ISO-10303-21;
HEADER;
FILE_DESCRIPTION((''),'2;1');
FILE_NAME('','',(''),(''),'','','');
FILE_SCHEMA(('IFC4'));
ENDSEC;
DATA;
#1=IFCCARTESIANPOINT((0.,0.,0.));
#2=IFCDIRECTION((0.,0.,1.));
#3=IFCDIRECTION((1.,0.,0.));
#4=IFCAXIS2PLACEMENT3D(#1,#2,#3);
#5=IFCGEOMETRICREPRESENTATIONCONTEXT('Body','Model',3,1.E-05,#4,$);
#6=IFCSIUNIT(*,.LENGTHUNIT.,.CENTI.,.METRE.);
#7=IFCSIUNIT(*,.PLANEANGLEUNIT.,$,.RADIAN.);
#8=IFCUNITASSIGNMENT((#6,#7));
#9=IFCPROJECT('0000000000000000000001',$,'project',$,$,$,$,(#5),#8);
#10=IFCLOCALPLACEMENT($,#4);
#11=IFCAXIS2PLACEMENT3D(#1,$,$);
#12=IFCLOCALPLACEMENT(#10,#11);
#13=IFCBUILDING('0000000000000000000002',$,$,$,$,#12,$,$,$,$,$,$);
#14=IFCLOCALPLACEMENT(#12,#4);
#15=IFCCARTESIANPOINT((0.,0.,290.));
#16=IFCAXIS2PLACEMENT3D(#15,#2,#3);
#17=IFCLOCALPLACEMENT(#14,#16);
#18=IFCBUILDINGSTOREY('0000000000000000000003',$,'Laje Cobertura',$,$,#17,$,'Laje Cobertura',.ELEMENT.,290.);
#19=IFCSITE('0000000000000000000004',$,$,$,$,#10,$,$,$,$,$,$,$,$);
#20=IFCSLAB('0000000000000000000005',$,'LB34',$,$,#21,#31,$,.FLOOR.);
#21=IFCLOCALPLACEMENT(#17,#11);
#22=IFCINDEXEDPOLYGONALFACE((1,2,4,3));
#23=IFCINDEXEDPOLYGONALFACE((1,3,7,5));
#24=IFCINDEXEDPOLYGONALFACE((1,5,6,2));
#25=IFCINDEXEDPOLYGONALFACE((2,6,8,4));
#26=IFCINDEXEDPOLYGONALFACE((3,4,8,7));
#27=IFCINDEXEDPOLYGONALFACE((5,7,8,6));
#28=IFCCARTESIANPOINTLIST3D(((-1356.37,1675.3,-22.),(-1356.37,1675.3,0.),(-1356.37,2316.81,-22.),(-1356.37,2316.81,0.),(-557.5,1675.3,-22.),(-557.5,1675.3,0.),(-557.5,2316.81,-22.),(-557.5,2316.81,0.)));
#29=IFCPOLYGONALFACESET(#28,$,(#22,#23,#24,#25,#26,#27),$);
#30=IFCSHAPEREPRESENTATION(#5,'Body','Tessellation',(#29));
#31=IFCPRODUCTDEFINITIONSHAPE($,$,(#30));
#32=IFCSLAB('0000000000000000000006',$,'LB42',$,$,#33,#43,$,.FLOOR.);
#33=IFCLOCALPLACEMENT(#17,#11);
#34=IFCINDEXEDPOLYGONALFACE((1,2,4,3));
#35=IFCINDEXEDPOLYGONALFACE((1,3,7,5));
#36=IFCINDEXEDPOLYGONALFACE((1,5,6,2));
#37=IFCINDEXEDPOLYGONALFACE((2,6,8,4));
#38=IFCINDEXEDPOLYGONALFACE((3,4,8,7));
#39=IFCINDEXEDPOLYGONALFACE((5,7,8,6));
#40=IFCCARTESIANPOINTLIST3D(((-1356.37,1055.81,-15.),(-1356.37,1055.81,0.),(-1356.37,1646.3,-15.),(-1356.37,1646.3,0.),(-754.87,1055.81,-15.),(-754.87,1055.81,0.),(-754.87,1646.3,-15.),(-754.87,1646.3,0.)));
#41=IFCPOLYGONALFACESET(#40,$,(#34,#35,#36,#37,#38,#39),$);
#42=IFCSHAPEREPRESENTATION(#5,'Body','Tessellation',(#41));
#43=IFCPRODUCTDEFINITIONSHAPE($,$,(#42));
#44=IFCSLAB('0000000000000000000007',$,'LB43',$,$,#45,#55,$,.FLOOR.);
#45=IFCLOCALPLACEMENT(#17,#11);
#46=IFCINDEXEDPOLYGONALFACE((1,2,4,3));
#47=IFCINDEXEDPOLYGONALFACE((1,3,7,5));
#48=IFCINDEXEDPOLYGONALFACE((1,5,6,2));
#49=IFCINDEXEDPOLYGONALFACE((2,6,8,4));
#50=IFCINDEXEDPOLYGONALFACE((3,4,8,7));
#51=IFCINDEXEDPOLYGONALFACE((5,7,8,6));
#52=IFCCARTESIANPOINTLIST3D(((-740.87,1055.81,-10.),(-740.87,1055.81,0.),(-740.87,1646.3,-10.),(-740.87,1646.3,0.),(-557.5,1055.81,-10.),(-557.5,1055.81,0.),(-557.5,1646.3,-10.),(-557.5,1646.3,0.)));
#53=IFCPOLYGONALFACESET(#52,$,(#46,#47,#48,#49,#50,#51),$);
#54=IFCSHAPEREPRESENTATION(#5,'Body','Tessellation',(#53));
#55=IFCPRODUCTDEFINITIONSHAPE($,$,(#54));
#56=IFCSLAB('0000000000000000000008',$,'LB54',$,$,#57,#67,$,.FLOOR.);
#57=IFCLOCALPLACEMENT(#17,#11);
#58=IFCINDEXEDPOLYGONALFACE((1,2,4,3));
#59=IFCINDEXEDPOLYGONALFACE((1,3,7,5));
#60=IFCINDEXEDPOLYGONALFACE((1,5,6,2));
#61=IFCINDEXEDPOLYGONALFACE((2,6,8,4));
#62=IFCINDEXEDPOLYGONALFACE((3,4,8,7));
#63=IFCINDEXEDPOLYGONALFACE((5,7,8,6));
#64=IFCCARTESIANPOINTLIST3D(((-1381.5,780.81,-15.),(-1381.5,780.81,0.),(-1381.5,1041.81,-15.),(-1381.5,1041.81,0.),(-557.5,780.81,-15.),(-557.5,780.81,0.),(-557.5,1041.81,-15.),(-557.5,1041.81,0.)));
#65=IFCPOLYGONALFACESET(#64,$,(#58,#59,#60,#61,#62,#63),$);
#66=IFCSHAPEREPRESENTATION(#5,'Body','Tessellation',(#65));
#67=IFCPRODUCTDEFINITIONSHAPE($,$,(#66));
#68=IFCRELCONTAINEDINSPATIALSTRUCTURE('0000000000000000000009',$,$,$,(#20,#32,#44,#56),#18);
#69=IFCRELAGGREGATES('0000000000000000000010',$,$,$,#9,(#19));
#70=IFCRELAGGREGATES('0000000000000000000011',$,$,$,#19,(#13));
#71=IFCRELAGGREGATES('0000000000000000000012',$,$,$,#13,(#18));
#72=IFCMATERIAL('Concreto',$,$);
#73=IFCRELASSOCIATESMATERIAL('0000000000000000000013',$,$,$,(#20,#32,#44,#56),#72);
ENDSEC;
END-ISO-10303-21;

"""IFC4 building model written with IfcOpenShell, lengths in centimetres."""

from ifc_helpers import new_model, si_unit, frame, origin, origin_with_axes, place, context, project, spatial, polyline, outline, extrude, material, element, save


model = new_model("IFC4")

# Units and contexts
model_context = context("Model", 3, precision=1e-05, world=origin_with_axes(), identifier="Body")
ifc_project = project(units=[si_unit("LENGTHUNIT", "METRE", prefix="CENTI"), si_unit("PLANEANGLEUNIT", "RADIAN")], contexts=[model_context])

# Site, building, storey
site_placement = place(None, origin_with_axes())
site = spatial("IfcSite", under=ifc_project, at=site_placement)
building_placement = place(site_placement, origin())
building = spatial("IfcBuilding", under=site, at=building_placement)
placement = place(building_placement, origin_with_axes())
storey_placement = place(placement, frame((0.0, 0.0, 290.0), z_axis=(0.0, 0.0, 1.0), x_axis=(1.0, 0.0, 0.0)))
storey = spatial("IfcBuildingStorey", under=building, at=storey_placement, Name="Laje Cobertura", LongName="Laje Cobertura", CompositionType="ELEMENT", Elevation=290.0)

# Shared definitions
ifc_material = material(Name="Concreto")

# Slabs
slab_1_placement = place(storey_placement, frame((-956.93, 1996.05, 0.0), z_axis=(0.0, 0.0, 1.0), x_axis=(1.0, 0.0, 0.0)))
element("IfcSlab", 1, at=slab_1_placement, inside=storey, material=ifc_material, Name="LB34", PredefinedType="FLOOR", context=model_context, shape_type="SolidModel", body=[
    extrude(outline(polyline([(399.44, 320.75), (-399.43, 320.75), (-399.44, -320.75), (399.43, -320.75), (399.44, 320.75), (399.44, 320.75)])), frame((0.0, 0.0, -22.0), z_axis=(0.0, 0.0, 1.0), x_axis=(1.0, 0.0, 0.0)), (0.0, 0.0, 1.0), 22.0),
])
slab_2_placement = place(storey_placement, frame((-1055.62, 1351.05, 0.0), z_axis=(0.0, 0.0, 1.0), x_axis=(1.0, 0.0, 0.0)))
element("IfcSlab", 2, at=slab_2_placement, inside=storey, material=ifc_material, Name="LB42", PredefinedType="FLOOR", context=model_context, shape_type="SolidModel", body=[
    extrude(outline(polyline([(300.75, 295.24), (-300.75, 295.24), (-300.75, -295.25), (300.75, -295.25), (300.75, 295.24), (300.75, 295.24)])), frame((0.0, 0.0, -15.0), z_axis=(0.0, 0.0, 1.0), x_axis=(1.0, 0.0, 0.0)), (0.0, 0.0, 1.0), 15.0),
])
slab_3_placement = place(storey_placement, frame((-649.18, 1351.06, 0.0), z_axis=(0.0, 0.0, 1.0), x_axis=(1.0, 0.0, 0.0)))
element("IfcSlab", 3, at=slab_3_placement, inside=storey, material=ifc_material, Name="LB43", PredefinedType="FLOOR", context=model_context, shape_type="SolidModel", body=[
    extrude(outline(polyline([(91.68, -295.25), (91.69, 295.24), (-91.69, 295.25), (-91.69, -295.25), (91.68, -295.25), (91.68, -295.25)])), frame((0.0, 0.0, -10.0), z_axis=(0.0, 0.0, 1.0), x_axis=(1.0, 0.0, 0.0)), (0.0, 0.0, 1.0), 10.0),
])
slab_4_placement = place(storey_placement, frame((-969.5, 911.31, 0.0), z_axis=(0.0, 0.0, 1.0), x_axis=(1.0, 0.0, 0.0)))
element("IfcSlab", 4, at=slab_4_placement, inside=storey, material=ifc_material, Name="LB54", PredefinedType="FLOOR", context=model_context, shape_type="SolidModel", body=[
    extrude(outline(polyline([(412.0, -130.5), (412.0, 130.5), (-412.0, 130.5), (-412.0, -130.5), (412.0, -130.5), (412.0, -130.5)])), frame((0.0, 0.0, -15.0), z_axis=(0.0, 0.0, 1.0), x_axis=(1.0, 0.0, 0.0)), (0.0, 0.0, 1.0), 15.0),
])

save(model, "model.ifc")
